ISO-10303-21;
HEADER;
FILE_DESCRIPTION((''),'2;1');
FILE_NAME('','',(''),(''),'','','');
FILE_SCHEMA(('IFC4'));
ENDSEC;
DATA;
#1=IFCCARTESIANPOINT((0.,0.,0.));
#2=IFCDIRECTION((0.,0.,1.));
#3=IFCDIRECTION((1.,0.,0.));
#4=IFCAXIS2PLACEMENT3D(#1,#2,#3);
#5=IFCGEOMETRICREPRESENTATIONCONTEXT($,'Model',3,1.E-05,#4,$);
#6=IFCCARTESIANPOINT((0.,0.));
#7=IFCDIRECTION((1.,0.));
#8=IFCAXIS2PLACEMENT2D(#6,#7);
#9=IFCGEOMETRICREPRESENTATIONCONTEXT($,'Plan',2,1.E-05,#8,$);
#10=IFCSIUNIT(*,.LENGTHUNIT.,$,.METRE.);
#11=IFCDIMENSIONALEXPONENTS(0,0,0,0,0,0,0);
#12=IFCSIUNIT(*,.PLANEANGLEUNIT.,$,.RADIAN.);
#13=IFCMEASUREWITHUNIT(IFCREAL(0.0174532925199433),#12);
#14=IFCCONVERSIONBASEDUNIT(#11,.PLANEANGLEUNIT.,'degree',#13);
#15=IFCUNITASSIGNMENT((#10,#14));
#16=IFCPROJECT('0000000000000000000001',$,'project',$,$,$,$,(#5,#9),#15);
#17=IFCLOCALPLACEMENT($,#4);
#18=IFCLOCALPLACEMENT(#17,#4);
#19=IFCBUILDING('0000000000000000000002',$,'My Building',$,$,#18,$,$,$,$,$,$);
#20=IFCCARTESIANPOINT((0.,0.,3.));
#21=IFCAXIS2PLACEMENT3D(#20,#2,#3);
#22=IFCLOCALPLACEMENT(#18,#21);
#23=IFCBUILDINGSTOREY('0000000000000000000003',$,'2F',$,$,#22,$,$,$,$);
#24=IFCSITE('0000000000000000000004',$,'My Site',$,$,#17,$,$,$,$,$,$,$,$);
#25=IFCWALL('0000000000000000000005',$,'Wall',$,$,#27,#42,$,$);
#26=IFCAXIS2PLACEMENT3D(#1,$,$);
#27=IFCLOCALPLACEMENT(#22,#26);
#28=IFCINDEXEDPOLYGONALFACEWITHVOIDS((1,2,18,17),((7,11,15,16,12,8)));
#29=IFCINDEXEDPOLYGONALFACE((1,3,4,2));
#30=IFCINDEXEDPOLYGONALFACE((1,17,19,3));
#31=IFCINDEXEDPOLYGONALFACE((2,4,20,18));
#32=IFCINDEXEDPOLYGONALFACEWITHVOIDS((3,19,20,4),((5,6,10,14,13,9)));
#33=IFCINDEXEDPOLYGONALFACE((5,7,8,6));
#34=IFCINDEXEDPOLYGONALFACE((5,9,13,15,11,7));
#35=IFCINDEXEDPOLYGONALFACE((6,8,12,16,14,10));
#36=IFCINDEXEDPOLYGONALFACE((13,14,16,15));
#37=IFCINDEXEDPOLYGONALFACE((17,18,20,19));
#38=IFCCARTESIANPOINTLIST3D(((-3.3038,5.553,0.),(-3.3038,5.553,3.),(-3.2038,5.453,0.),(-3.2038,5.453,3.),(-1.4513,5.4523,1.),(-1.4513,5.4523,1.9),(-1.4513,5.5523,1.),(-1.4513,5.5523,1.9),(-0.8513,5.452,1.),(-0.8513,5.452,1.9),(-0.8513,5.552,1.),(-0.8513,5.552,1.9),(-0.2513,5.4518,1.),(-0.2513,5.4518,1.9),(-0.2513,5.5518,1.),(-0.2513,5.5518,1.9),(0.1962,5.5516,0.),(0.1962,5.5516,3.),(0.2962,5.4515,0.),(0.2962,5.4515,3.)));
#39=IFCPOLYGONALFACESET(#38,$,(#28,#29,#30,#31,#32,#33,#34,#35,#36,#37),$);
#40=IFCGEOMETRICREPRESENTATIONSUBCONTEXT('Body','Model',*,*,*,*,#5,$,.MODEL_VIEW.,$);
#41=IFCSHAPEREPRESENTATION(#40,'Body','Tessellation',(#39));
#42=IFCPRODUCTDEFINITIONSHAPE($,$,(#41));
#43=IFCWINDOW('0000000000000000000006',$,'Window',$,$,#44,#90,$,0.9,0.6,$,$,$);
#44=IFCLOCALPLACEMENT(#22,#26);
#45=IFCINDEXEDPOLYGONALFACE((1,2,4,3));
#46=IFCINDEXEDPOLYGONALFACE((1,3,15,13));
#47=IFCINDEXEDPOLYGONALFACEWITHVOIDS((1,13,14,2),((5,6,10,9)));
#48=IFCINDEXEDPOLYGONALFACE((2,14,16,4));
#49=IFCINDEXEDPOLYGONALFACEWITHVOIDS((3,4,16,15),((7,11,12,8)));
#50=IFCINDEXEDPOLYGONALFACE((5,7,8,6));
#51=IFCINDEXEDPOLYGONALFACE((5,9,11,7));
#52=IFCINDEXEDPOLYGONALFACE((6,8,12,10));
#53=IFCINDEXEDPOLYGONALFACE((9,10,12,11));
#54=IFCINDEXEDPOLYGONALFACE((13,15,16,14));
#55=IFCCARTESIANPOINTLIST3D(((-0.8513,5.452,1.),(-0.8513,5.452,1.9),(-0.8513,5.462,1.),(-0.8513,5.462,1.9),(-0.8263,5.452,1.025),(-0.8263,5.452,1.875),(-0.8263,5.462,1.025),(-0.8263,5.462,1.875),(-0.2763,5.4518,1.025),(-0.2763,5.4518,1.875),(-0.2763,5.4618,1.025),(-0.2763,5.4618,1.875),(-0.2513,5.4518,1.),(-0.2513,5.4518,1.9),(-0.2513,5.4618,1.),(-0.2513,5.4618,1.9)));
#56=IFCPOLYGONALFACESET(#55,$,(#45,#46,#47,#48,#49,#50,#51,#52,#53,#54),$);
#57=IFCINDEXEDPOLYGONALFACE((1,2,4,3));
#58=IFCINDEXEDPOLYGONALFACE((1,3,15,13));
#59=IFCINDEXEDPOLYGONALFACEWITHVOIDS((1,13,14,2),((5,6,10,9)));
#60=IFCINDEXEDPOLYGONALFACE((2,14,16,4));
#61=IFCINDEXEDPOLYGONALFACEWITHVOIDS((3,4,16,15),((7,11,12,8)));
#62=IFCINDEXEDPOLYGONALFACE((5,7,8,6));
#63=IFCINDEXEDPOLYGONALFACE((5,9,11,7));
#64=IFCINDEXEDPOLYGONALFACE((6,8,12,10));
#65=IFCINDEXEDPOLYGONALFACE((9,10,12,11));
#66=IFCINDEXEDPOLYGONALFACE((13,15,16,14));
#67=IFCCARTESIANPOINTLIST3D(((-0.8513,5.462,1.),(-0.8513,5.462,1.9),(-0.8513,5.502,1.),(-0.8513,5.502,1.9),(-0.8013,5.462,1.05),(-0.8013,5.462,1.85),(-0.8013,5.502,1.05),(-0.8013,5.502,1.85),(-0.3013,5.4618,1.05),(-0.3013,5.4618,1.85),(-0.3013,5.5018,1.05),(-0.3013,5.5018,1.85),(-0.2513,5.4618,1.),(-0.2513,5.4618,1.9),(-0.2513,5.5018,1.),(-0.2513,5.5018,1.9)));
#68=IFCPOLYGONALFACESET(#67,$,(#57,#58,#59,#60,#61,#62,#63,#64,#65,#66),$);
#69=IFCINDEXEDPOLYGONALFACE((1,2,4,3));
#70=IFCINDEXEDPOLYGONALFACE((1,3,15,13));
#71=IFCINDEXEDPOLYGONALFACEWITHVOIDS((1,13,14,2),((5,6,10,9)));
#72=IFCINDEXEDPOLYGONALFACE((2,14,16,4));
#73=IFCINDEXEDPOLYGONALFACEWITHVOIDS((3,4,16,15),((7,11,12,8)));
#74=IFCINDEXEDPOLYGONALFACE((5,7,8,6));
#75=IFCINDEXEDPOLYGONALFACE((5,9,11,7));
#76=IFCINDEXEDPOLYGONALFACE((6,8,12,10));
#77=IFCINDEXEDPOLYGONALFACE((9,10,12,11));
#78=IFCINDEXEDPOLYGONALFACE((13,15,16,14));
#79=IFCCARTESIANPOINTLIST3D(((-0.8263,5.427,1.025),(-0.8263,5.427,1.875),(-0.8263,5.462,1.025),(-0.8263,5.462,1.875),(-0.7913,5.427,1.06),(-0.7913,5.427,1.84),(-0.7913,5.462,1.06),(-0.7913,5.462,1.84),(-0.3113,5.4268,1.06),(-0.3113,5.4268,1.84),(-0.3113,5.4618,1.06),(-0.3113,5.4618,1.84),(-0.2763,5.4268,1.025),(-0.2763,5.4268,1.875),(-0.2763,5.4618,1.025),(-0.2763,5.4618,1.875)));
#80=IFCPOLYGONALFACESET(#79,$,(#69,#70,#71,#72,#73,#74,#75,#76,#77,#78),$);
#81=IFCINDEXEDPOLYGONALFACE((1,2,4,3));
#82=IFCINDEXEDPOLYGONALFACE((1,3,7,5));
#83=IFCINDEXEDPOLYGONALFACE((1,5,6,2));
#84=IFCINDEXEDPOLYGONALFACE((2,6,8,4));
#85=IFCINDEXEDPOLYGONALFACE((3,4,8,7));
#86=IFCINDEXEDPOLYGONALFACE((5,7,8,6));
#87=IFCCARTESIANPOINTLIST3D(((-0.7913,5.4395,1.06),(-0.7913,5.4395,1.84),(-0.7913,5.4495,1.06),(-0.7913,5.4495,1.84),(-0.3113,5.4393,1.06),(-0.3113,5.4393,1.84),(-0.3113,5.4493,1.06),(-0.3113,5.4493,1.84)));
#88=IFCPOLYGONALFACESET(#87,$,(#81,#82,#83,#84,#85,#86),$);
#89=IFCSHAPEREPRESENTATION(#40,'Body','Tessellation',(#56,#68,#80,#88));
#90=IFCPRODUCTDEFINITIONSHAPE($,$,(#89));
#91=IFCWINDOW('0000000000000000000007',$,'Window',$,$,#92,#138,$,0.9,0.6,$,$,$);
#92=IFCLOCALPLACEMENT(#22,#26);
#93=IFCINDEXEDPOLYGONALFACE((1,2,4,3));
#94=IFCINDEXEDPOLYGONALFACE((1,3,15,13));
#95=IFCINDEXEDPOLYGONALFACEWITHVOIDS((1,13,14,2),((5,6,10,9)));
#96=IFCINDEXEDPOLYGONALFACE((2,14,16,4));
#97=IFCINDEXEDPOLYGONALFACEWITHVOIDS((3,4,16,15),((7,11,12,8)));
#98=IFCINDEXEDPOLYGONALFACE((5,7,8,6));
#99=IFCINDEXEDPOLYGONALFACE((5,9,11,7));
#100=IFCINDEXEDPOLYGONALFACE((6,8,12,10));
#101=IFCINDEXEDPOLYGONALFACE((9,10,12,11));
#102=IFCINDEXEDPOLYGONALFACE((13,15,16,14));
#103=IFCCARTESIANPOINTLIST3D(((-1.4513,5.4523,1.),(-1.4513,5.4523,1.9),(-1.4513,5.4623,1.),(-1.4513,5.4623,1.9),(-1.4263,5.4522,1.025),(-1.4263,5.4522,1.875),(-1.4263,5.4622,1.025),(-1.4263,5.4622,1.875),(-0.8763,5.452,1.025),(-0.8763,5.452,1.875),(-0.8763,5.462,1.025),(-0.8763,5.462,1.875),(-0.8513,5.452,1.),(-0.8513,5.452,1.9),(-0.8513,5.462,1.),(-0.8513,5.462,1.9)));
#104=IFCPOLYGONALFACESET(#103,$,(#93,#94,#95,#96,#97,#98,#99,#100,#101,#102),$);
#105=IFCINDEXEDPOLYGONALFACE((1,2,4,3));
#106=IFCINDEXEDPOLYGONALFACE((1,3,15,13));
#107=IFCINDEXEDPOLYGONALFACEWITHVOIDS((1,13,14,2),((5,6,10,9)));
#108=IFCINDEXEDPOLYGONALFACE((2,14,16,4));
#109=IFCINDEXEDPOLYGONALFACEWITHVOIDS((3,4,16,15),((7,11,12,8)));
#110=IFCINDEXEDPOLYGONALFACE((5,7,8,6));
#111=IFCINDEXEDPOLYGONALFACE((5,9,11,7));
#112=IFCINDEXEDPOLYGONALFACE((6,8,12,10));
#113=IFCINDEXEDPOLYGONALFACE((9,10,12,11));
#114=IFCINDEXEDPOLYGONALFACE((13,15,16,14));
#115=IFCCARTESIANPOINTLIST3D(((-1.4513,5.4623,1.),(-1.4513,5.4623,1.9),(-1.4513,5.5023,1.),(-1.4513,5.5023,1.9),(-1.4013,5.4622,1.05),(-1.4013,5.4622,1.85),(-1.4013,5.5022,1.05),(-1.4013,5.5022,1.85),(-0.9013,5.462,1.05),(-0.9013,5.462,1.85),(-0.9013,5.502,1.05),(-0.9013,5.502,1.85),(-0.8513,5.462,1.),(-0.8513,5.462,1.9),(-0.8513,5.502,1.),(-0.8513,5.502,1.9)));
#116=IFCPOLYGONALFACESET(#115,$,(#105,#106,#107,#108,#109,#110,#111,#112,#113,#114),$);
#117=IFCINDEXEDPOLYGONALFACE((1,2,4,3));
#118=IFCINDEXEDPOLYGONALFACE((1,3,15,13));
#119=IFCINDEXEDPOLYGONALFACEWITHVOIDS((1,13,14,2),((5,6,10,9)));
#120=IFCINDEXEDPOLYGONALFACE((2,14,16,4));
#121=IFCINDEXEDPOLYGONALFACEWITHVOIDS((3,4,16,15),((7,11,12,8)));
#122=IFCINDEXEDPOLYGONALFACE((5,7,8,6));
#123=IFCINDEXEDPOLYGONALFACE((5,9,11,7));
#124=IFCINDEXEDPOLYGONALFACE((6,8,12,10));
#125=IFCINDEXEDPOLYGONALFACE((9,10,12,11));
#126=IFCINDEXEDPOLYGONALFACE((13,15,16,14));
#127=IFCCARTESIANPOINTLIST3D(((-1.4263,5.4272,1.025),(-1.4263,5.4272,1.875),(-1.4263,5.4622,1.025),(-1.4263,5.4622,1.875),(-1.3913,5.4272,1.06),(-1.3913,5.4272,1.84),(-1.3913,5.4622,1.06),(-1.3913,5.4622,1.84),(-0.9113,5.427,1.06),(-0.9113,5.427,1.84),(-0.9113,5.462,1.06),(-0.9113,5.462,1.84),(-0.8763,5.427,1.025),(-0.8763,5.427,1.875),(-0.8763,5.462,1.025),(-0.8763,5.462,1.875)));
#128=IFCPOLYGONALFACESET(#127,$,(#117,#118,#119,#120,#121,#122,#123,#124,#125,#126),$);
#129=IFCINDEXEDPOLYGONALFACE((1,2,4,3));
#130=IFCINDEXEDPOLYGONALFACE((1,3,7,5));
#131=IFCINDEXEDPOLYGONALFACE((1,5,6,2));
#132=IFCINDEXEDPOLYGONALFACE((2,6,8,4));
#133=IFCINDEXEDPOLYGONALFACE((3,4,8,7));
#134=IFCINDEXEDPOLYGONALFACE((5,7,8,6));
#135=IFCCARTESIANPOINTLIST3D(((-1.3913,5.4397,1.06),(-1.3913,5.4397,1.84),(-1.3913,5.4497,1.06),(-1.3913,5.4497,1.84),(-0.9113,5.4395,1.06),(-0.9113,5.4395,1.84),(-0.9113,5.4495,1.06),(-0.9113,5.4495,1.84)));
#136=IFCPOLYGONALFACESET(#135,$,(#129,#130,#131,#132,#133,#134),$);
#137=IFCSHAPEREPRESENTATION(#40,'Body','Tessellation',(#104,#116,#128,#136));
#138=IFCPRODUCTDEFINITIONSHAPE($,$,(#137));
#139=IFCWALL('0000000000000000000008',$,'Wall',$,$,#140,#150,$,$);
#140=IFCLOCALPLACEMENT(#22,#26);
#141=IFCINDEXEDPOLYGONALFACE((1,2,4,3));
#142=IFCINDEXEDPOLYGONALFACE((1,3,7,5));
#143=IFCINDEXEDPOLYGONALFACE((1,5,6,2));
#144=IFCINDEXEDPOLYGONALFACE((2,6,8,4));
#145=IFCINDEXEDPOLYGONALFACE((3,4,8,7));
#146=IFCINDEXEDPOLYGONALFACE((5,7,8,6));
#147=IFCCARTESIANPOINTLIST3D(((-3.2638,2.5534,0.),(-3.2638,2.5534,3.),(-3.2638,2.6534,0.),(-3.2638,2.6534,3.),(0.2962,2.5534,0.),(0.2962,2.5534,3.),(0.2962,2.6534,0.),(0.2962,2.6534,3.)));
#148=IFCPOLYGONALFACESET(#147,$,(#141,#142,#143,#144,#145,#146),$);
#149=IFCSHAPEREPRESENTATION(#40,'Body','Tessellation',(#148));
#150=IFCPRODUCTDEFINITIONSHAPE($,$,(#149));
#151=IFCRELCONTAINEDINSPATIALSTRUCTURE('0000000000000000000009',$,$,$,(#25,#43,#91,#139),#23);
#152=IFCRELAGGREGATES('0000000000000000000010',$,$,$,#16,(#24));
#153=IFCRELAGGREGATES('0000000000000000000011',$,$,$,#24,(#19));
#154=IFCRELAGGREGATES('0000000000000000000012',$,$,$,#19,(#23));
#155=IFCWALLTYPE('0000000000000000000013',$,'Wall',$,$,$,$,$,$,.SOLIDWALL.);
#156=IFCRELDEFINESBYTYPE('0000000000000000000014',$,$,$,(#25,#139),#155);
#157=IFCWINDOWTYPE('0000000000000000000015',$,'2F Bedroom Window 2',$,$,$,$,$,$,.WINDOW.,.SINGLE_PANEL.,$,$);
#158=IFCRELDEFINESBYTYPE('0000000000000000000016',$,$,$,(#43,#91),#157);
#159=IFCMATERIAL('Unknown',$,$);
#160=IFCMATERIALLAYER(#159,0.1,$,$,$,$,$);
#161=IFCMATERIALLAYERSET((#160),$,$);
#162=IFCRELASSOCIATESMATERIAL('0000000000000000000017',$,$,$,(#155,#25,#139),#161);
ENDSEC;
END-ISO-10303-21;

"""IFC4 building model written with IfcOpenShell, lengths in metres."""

from ifc_helpers import new_model, entity, si_unit, converted_unit, frame, origin_with_axes, origin_2d_with_axis, place, context, subcontext, project, spatial, line, indexed_curve, outline, extrude, shape, source, transform, mapped, material, layer, layer_set, layer_usage, type_object, type_shapes, element, fill, save


model = new_model("IFC4")

# Units and contexts
model_context = context("Model", 3, precision=1e-05, world=origin_with_axes())
plan_context = context("Plan", 2, precision=1e-05, world=origin_2d_with_axis())
body_context_1 = subcontext(model_context, "Body", "Model", "MODEL_VIEW")
body_context_2 = subcontext(plan_context, "Body", "Plan", "PLAN_VIEW")
ifc_project = project(units=[si_unit("LENGTHUNIT", "METRE"), converted_unit("PLANEANGLEUNIT", "degree", entity("IfcReal", 0.0174532925199433), si_unit("PLANEANGLEUNIT", "RADIAN"), dimensions=[0, 0, 0, 0, 0, 0, 0])], contexts=[model_context, plan_context])

# Site, building, storey
site_placement = place(None, origin_with_axes())
site = spatial("IfcSite", under=ifc_project, at=site_placement, Name="My Site")
building_placement = place(site_placement, origin_with_axes())
building = spatial("IfcBuilding", under=site, at=building_placement, Name="My Building")
storey_placement = place(building_placement, frame((0.0, 0.0, 3.0), z_axis=(0.0, 0.0, 1.0), x_axis=(1.0, 0.0, 0.0)))
storey = spatial("IfcBuildingStorey", under=building, at=storey_placement, Name="2F")

# Shared definitions
ifc_material = material(Name="Unknown")

# Shared definitions
ifc_layer = layer(ifc_material, 0.1)
ifc_layer_set = layer_set([ifc_layer])
wall_type = type_object("IfcWallType", Name="Wall", PredefinedType="SOLIDWALL", material=ifc_layer_set)

# Wall, openings, windows
ifc_layer_usage_1 = layer_usage(ifc_layer_set, "AXIS2", "POSITIVE", 0.0)
wall_1_placement = place(storey_placement, frame((0.1962, 5.5516, 0.0), z_axis=(0.0, 0.0, 1.0), x_axis=(-1.0, 0.000416, 0.0)))
wall_1 = element("IfcWall", 1, at=wall_1_placement, inside=storey, type_object=wall_type, material=ifc_layer_usage_1, Name="Wall", context=body_context_1, shape_type="SweptSolid", body=[
    extrude(outline(indexed_curve([(0.0, 0.0), (-0.1, 0.1), (3.4, 0.1), (3.5, 0.0)], segments=[line(1, 2, 3, 4, 1)])), origin_with_axes(), (0.0, 0.0, 1.0), 3.0),
])
shared_shape_1 = source(origin_with_axes(), body_context_1, "Body", "SweptSolid", [
    extrude(outline(indexed_curve([(0.0, 0.0), (0.6, 0.0), (0.6, 0.9), (0.0, 0.9)], segments=[line(1, 2, 3, 4, 1)])), frame((0.0, -0.6, 0.0), z_axis=(0.0, -1.0, 0.0), x_axis=(1.0, 0.0, 0.0)), (0.0, 0.0, -1.0), 1.2),
])
opening_1_placement = place(wall_1_placement, frame((0.4475, 0.0, 1.0), z_axis=(0.0, 0.0, 1.0), x_axis=(1.0, 0.0, 0.0)))
opening_1 = element("IfcOpeningElement", 2, at=opening_1_placement, cuts=wall_1, PredefinedType="OPENING", context=body_context_1, shape_type="MappedRepresentation", body=[
    mapped(shared_shape_1, transform((0.0, 0.0, 0.0), x_axis=(1.0, 0.0, 0.0), y_axis=(0.0, 1.0, 0.0), z_axis=(0.0, 0.0, 1.0), scale=1.0)),
])
opening_2_placement = place(wall_1_placement, frame((1.0475, 0.0, 1.0), z_axis=(0.0, 0.0, 1.0), x_axis=(1.0, 0.0, 0.0)))
opening_2 = element("IfcOpeningElement", 3, at=opening_2_placement, cuts=wall_1, PredefinedType="OPENING", context=body_context_1, shape_type="MappedRepresentation", body=[
    mapped(shared_shape_1, transform((0.0, 0.0, 0.0), x_axis=(1.0, 0.0, 0.0), y_axis=(0.0, 1.0, 0.0), z_axis=(0.0, 0.0, 1.0), scale=1.0)),
])
window_type_1 = type_object("IfcWindowType", Name="2F Bedroom Window 2", PartitioningType="SINGLE_PANEL", PredefinedType="WINDOW")
shared_shape_2 = source(origin_with_axes(), body_context_1, "Body", "SweptSolid", [
    extrude(outline(indexed_curve([(0.0, 0.0), (0.6, 0.0), (0.6, 0.9), (0.0, 0.9)], segments=[line(1, 2, 3, 4, 1)]), holes=[indexed_curve([(0.025, 0.025), (0.575, 0.025), (0.575, 0.875), (0.025, 0.875)], segments=[line(1, 2, 3, 4, 1)])]), frame((0.0, 0.09, 0.0), z_axis=(0.0, -1.0, 0.0), x_axis=(1.0, 0.0, 0.0)), (0.0, 0.0, -1.0), 0.01),
    extrude(outline(indexed_curve([(0.0, 0.0), (0.6, 0.0), (0.6, 0.9), (0.0, 0.9)], segments=[line(1, 2, 3, 4, 1)]), holes=[indexed_curve([(0.05, 0.05), (0.55, 0.05), (0.55, 0.85), (0.05, 0.85)], segments=[line(1, 2, 3, 4, 1)])]), frame((0.0, 0.05, 0.0), z_axis=(0.0, -1.0, 0.0), x_axis=(1.0, 0.0, 0.0)), (0.0, 0.0, -1.0), 0.04),
    extrude(outline(indexed_curve([(0.0, 0.0), (0.55, 0.0), (0.55, 0.85), (0.0, 0.85)], segments=[line(1, 2, 3, 4, 1)]), holes=[indexed_curve([(0.035, 0.035), (0.515, 0.035), (0.515, 0.815), (0.035, 0.815)], segments=[line(1, 2, 3, 4, 1)])]), frame((0.025, 0.09, 0.025), z_axis=(0.0, -1.0, 0.0), x_axis=(1.0, 0.0, 0.0)), (0.0, 0.0, -1.0), 0.035),
    extrude(outline(indexed_curve([(0.035, 0.035), (0.515, 0.035), (0.515, 0.815), (0.035, 0.815)], segments=[line(1, 2, 3, 4, 1)])), frame((0.025, 0.1025, 0.025), z_axis=(0.0, -1.0, 0.0), x_axis=(1.0, 0.0, 0.0)), (0.0, 0.0, -1.0), 0.01),
])
shared_shape_3 = source(origin_with_axes(), body_context_2, "Body", "Curve2D", [
    entity("IfcIndexedPolyCurve", entity("IfcCartesianPointList2D", [[0.05, 0.05], [0.55, 0.05]])),
    entity("IfcIndexedPolyCurve", entity("IfcCartesianPointList2D", [[0.0, 0.1], [0.025, 0.1], [0.025, 0.09], [0.05, 0.09], [0.05, 0.05], [0.0, 0.05]]), [entity("IfcLineIndex", [1, 2, 3, 4, 5, 6, 1])]),
    entity("IfcIndexedPolyCurve", entity("IfcCartesianPointList2D", [[0.6, 0.1], [0.575, 0.1], [0.575, 0.09], [0.55, 0.09], [0.55, 0.05], [0.6, 0.05]]), [entity("IfcLineIndex", [1, 2, 3, 4, 5, 6, 1])]),
    entity("IfcIndexedPolyCurve", entity("IfcCartesianPointList2D", [[0.025, 0.09], [0.06, 0.09], [0.06, 0.125], [0.025, 0.125]]), [entity("IfcLineIndex", [1, 2, 3, 4, 1])]),
    entity("IfcIndexedPolyCurve", entity("IfcCartesianPointList2D", [[0.575, 0.09], [0.54, 0.09], [0.54, 0.125], [0.575, 0.125]]), [entity("IfcLineIndex", [1, 2, 3, 4, 1])]),
    entity("IfcIndexedPolyCurve", entity("IfcCartesianPointList2D", [[0.06, 0.09], [0.54, 0.09]])),
    entity("IfcIndexedPolyCurve", entity("IfcCartesianPointList2D", [[0.06, 0.125], [0.54, 0.125]])),
    entity("IfcIndexedPolyCurve", entity("IfcCartesianPointList2D", [[0.06, 0.1075], [0.54, 0.1075]])),
])
type_shapes(window_type_1, [shared_shape_2, shared_shape_3])
window_1_placement = place(opening_1_placement, frame((0.0, 0.0, 0.0), z_axis=(0.0, 0.0, 1.0), x_axis=(1.0, 0.0, 0.0)))
window_1 = element("IfcWindow", 4, at=window_1_placement, inside=storey, type_object=window_type_1, Name="Window", OverallHeight=0.9, OverallWidth=0.6, shapes=[
    shape(body_context_1, "Body", "MappedRepresentation", [mapped(shared_shape_2, transform((0.0, 0.0, 0.0), x_axis=(1.0, 0.0, 0.0), y_axis=(0.0, 1.0, 0.0), z_axis=(0.0, 0.0, 1.0), scale=1.0))]),
    shape(body_context_2, "Body", "MappedRepresentation", [mapped(shared_shape_3, transform((0.0, 0.0, 0.0), x_axis=(1.0, 0.0, 0.0), y_axis=(0.0, 1.0, 0.0), z_axis=(0.0, 0.0, 1.0), scale=1.0))]),
])
fill(opening_1, window_1)
window_2_placement = place(opening_2_placement, origin_with_axes())
window_2 = element("IfcWindow", 5, at=window_2_placement, inside=storey, type_object=window_type_1, Name="Window", OverallHeight=0.9, OverallWidth=0.6, shapes=[
    shape(body_context_1, "Body", "MappedRepresentation", [mapped(shared_shape_2, transform((0.0, 0.0, 0.0), x_axis=(1.0, 0.0, 0.0), y_axis=(0.0, 1.0, 0.0), z_axis=(0.0, 0.0, 1.0), scale=1.0))]),
    shape(body_context_2, "Body", "MappedRepresentation", [mapped(shared_shape_3, transform((0.0, 0.0, 0.0), x_axis=(1.0, 0.0, 0.0), y_axis=(0.0, 1.0, 0.0), z_axis=(0.0, 0.0, 1.0), scale=1.0))]),
])
fill(opening_2, window_2)

# Wall
ifc_layer_usage_2 = layer_usage(ifc_layer_set, "AXIS2", "POSITIVE", 0.0)
wall_2_placement = place(storey_placement, frame((-3.2638, 2.5534, 0.0), z_axis=(0.0, 0.0, 1.0), x_axis=(1.0, 0.0, 0.0)))
element("IfcWall", 6, at=wall_2_placement, inside=storey, type_object=wall_type, material=ifc_layer_usage_2, Name="Wall", context=body_context_1, shape_type="SweptSolid", body=[
    extrude(outline(indexed_curve([(0.0, 0.0), (0.0, 0.1), (3.56, 0.1), (3.56, 0.0)], segments=[line(1, 2, 3, 4, 1)])), origin_with_axes(), (0.0, 0.0, 1.0), 3.0),
])

save(model, "model.ifc")
